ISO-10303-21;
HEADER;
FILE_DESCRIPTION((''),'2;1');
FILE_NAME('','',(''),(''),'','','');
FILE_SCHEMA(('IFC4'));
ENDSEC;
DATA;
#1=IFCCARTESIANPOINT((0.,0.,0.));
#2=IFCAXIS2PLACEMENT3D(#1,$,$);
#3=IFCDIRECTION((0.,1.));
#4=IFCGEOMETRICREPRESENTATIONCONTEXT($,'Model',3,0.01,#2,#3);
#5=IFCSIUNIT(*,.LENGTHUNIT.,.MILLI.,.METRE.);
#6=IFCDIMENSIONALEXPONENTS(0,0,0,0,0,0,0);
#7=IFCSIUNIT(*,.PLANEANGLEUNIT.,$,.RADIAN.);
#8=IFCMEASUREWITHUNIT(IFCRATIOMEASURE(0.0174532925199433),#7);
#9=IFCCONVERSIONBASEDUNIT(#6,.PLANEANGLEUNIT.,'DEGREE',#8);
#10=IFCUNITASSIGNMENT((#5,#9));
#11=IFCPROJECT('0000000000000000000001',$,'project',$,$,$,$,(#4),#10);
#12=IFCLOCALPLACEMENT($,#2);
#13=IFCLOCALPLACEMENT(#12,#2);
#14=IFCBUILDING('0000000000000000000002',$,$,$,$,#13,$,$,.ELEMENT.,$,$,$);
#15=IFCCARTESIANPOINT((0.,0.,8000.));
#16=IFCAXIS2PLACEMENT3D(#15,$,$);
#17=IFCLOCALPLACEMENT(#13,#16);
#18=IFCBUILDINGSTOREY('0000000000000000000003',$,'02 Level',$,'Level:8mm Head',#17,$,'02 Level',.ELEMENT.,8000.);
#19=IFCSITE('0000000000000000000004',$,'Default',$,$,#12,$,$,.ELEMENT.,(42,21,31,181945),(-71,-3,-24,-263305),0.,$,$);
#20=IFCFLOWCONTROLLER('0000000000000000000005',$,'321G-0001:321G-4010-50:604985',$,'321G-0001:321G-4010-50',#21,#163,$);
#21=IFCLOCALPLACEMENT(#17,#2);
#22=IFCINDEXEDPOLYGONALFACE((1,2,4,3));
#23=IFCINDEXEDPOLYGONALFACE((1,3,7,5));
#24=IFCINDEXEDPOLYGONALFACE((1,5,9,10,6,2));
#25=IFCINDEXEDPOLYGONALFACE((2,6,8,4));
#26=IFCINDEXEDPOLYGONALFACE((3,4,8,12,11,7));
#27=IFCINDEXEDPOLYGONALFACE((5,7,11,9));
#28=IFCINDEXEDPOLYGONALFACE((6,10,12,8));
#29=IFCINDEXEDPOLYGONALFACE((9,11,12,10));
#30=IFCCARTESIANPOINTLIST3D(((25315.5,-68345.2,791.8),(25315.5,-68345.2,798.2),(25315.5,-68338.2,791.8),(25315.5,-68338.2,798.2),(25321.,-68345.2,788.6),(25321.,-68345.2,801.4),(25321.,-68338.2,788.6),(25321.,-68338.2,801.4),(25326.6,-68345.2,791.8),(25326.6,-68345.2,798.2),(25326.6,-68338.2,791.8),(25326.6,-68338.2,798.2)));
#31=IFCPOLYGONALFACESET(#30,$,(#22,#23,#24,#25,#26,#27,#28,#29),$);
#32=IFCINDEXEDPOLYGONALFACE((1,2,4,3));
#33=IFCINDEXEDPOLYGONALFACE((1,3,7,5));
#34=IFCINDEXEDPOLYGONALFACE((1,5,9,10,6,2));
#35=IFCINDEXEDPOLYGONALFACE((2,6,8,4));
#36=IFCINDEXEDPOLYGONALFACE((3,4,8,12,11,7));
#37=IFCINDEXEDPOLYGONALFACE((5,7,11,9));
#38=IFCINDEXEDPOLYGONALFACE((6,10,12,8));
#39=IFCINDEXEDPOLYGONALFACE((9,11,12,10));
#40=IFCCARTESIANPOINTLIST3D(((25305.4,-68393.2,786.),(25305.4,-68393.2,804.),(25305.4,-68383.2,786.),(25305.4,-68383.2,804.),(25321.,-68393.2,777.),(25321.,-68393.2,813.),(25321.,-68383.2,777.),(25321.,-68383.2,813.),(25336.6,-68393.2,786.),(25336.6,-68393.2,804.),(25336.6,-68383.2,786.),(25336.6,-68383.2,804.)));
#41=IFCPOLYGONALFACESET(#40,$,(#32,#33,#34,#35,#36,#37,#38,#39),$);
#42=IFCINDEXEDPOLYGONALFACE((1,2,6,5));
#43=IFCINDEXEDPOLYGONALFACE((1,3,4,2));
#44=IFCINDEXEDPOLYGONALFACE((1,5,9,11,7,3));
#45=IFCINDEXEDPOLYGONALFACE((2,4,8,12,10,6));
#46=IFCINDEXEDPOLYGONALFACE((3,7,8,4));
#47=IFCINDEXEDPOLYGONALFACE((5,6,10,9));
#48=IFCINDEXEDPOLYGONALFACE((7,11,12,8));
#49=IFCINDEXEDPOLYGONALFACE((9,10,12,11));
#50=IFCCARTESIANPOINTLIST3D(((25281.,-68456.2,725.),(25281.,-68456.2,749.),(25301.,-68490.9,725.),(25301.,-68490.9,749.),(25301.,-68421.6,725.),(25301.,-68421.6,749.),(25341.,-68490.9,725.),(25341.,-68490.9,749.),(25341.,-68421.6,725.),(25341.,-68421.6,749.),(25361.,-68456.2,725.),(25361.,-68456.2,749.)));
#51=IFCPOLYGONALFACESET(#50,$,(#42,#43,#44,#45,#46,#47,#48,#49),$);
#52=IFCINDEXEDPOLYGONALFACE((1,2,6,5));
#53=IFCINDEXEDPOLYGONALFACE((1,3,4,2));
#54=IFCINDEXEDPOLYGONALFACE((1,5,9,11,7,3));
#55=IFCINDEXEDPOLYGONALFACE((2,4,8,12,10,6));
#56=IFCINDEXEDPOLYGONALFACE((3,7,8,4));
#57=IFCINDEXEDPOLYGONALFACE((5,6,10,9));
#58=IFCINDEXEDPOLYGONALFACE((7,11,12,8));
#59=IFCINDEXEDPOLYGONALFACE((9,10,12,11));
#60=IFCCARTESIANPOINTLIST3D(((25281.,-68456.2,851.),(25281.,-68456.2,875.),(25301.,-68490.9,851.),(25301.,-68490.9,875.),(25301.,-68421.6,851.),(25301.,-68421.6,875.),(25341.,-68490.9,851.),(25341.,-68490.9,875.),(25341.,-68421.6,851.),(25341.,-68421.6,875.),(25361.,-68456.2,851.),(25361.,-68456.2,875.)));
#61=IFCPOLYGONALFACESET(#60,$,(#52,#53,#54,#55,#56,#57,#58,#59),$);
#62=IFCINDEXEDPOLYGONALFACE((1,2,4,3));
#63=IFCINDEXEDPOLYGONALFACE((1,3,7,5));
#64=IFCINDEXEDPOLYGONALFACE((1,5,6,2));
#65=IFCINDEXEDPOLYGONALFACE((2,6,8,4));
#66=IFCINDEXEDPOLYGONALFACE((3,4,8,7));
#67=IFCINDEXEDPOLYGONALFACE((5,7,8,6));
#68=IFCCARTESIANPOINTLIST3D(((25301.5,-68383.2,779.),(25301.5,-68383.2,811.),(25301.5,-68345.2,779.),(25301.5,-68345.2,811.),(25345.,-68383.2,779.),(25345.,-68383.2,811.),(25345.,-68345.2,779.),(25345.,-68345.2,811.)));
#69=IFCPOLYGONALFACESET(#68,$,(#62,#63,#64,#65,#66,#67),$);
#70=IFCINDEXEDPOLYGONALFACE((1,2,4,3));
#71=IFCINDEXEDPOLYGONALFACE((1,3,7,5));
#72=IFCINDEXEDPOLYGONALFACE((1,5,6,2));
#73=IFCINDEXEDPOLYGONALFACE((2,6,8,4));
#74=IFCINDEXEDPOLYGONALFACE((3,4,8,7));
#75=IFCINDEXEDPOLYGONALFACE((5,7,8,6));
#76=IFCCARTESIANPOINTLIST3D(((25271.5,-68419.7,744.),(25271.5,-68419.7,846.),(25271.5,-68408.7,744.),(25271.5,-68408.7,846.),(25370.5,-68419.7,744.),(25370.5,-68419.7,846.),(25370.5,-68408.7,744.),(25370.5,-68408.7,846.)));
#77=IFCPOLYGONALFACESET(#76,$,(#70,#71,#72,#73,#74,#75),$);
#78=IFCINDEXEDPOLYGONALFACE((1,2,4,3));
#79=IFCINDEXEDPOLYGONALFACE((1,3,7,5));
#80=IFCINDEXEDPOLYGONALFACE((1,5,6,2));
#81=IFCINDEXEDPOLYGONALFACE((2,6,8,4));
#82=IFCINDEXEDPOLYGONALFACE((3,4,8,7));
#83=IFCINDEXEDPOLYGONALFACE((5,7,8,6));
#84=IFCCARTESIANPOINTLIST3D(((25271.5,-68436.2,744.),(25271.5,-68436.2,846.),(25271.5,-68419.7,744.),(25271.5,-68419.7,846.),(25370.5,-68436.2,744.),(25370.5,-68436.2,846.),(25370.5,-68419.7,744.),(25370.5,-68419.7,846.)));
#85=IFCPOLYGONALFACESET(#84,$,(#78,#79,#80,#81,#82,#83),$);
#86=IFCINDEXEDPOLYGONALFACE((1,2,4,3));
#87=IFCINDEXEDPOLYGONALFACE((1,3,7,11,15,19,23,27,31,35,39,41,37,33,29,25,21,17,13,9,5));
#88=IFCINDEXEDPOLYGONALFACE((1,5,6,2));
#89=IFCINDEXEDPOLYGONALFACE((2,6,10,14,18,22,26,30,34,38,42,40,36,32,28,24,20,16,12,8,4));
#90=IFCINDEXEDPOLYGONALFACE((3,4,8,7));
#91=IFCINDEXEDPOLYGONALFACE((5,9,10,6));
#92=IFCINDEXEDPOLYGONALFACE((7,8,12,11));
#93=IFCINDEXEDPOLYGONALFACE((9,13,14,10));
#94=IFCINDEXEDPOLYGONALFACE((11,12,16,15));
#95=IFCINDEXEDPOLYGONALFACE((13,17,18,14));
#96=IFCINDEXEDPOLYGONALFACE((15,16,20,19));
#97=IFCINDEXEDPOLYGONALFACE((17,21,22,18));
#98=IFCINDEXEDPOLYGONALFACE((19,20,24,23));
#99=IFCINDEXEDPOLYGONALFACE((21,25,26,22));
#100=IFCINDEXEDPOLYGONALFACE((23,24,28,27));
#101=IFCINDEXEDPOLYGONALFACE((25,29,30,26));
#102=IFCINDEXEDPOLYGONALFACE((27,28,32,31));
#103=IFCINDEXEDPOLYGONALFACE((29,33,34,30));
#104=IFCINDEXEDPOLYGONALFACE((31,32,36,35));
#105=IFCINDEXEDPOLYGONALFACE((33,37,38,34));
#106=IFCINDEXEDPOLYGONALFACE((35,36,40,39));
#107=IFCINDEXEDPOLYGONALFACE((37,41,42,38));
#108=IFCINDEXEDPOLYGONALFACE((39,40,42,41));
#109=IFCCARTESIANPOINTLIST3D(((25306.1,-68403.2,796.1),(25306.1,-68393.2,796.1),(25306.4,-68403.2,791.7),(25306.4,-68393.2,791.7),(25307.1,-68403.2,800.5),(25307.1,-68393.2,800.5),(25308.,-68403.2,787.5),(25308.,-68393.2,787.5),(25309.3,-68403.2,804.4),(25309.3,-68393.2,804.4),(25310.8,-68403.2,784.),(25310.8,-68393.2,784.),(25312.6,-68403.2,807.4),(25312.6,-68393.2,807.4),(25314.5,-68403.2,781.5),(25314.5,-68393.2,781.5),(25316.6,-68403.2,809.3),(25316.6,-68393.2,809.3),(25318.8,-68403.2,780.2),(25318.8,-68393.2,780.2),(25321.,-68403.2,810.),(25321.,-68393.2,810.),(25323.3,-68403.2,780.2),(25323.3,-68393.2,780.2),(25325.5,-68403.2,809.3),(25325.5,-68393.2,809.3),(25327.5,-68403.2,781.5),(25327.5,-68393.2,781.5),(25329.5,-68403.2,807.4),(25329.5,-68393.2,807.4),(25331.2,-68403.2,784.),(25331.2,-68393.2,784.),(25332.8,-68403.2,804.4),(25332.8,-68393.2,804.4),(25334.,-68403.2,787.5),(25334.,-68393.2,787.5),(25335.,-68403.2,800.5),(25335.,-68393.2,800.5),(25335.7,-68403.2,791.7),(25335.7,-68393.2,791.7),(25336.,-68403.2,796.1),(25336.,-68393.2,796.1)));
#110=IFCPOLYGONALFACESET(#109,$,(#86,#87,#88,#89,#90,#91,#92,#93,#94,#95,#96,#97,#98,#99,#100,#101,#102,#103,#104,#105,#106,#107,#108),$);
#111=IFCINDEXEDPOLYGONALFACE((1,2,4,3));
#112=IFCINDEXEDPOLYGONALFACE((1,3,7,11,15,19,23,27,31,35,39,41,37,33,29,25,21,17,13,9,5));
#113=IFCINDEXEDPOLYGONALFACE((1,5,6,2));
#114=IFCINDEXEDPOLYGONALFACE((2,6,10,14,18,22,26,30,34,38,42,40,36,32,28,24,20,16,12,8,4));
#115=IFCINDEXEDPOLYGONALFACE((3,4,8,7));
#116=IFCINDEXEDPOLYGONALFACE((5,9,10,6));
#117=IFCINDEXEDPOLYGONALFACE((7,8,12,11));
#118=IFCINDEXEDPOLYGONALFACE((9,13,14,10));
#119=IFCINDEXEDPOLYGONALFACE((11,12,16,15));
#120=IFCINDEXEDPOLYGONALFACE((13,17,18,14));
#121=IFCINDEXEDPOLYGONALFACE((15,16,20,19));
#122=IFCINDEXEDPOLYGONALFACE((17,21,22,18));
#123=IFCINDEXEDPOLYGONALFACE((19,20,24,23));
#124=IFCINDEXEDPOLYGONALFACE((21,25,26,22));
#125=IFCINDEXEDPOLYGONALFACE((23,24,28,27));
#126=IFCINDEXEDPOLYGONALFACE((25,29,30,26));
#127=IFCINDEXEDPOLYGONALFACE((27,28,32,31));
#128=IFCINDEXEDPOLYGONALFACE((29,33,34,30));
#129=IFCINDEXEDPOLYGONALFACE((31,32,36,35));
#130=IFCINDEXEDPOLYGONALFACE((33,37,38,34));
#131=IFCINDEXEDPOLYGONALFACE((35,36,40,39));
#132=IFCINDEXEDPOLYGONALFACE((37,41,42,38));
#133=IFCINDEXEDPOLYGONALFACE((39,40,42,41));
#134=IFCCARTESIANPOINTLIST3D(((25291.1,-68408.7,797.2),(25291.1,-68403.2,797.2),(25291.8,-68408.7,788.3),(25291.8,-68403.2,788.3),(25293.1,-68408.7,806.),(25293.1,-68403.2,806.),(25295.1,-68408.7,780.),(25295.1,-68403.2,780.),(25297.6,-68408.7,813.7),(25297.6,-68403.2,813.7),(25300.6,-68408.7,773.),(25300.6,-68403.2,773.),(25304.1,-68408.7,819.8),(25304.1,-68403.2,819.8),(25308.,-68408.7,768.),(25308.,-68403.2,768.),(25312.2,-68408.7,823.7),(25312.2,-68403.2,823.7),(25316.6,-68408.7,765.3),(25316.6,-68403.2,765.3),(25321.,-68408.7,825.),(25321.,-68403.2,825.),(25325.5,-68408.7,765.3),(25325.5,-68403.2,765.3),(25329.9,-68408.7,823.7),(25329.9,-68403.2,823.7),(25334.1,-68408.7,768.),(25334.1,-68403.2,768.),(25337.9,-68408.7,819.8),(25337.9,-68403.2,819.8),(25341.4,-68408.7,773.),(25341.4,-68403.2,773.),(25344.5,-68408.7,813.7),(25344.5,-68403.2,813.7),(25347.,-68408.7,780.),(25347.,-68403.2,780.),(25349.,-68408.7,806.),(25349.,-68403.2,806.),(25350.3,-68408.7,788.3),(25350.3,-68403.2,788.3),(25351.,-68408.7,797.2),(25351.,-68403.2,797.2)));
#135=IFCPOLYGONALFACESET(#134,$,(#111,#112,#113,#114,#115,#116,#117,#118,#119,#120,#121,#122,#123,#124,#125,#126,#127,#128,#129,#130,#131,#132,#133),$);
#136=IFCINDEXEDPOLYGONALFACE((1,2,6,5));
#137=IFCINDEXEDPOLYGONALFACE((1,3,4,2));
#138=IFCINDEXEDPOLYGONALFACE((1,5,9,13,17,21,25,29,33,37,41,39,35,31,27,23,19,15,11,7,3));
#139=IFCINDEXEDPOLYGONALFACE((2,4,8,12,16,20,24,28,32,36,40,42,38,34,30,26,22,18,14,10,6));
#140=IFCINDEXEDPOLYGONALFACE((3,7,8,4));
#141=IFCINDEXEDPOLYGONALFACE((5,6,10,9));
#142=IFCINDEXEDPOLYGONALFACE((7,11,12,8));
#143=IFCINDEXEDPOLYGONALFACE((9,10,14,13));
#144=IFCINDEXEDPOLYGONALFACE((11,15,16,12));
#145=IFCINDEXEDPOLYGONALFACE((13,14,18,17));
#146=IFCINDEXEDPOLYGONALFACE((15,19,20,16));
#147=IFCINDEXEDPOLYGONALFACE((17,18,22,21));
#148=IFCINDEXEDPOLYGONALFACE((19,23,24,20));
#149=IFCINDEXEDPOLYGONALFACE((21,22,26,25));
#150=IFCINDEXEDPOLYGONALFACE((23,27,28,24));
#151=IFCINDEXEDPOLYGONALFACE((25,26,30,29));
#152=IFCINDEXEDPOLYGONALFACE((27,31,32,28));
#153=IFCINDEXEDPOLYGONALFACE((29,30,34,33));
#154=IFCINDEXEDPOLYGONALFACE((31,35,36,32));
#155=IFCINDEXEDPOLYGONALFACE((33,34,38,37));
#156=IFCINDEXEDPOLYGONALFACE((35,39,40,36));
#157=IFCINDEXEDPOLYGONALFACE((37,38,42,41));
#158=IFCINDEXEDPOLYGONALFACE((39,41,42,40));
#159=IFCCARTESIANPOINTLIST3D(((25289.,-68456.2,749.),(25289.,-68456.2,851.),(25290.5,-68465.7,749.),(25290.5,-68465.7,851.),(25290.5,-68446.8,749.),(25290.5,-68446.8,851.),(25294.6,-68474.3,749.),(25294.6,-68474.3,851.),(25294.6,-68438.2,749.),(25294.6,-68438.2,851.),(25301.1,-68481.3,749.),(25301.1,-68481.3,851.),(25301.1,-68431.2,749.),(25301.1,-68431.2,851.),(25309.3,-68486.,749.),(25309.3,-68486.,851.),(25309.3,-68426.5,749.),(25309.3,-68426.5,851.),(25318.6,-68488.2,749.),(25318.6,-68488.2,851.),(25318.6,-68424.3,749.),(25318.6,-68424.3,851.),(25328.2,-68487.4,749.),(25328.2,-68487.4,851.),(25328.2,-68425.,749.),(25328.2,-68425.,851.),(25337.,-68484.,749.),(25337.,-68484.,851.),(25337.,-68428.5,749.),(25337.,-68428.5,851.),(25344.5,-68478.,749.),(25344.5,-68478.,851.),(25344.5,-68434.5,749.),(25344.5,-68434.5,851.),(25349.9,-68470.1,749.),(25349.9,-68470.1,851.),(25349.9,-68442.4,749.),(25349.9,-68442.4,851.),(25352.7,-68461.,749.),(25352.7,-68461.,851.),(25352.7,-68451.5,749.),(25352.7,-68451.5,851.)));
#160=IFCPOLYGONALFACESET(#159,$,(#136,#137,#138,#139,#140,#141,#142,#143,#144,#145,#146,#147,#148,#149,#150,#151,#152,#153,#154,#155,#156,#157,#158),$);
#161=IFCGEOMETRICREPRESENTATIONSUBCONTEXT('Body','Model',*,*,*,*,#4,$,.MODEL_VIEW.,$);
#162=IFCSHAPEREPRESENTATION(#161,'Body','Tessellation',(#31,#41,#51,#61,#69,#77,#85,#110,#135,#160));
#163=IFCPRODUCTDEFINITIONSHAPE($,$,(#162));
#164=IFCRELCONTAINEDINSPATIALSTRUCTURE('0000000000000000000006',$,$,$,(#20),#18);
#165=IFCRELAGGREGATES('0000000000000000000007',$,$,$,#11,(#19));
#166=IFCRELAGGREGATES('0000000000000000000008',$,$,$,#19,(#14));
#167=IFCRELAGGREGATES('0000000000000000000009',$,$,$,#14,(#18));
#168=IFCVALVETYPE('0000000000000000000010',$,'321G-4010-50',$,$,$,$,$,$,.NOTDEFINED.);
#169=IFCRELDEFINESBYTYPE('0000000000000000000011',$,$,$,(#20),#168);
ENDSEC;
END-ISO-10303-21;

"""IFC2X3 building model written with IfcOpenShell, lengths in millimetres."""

from ifc_helpers import new_model, entity, si_unit, converted_unit, direction, frame, frame_2d, origin, origin_2d_with_axis, place, context, subcontext, project, spatial, polyline, rectangle, circle, outline, extrude, source, transform, mapped, type_object, type_shapes, element, save


model = new_model("IFC2X3")

# Units and contexts
model_context = context("Model", 3, precision=0.01, world=origin(), true_north=direction((0.0, 1.0)))
body_context = subcontext(model_context, "Body", "Model", "MODEL_VIEW")
ifc_project = project(units=[si_unit("LENGTHUNIT", "METRE", prefix="MILLI"), converted_unit("PLANEANGLEUNIT", "DEGREE", entity("IfcRatioMeasure", 0.0174532925199433), si_unit("PLANEANGLEUNIT", "RADIAN"), dimensions=[0, 0, 0, 0, 0, 0, 0])], contexts=[model_context])

# Site, building, storey
site_placement = place(None, origin())
site = spatial("IfcSite", under=ifc_project, at=site_placement, Name="Default", CompositionType="ELEMENT", RefLatitude=(42, 21, 31, 181945), RefLongitude=(-71, -3, -24, -263305), RefElevation=0.0)
building_placement = place(site_placement, origin())
building = spatial("IfcBuilding", under=site, at=building_placement, CompositionType="ELEMENT")
storey_placement = place(building_placement, frame((0.0, 0.0, 8000.0)))
storey = spatial("IfcBuildingStorey", under=building, at=storey_placement, Name="02 Level", ObjectType="Level:8mm Head", LongName="02 Level", CompositionType="ELEMENT", Elevation=8000.0)

# Flow controller
valve_type_1 = type_object("IfcValveType", Name="321G-4010-50", PredefinedType="NOTDEFINED")
shared_shape_1 = source(origin(), body_context, "Body", "SweptSolid", [
    extrude(outline(polyline([(-3.2, -5.5), (3.2, -5.5), (6.4, 0.0), (3.2, 5.5), (-3.2, 5.5), (-6.4, 0.0), (-3.2, -5.5)])), frame((-5.0, 0.0, 111.0), z_axis=(0.0, 0.0, 1.0), x_axis=(0.5, 0.866025, 0.0)), (0.0, 0.0, 1.0), 7.0),
    extrude(outline(polyline([(-9.0, -15.6), (9.0, -15.6), (18.0, 0.0), (9.0, 15.6), (-9.0, 15.6), (-18.0, 0.0), (-9.0, -15.6)])), frame((-5.0, 0.0, 63.0), z_axis=(0.0, 0.0, 1.0), x_axis=(0.5, 0.866025, 0.0)), (0.0, 0.0, 1.0), 10.0),
    extrude(outline(polyline([(-20.0, -34.6), (20.0, -34.6), (40.0, 0.0), (20.0, 34.6), (-20.0, 34.6), (-40.0, 0.0), (-20.0, -34.6)])), frame((-75.0, 0.0, 0.0), z_axis=(1.0, 0.0, 0.0), x_axis=(0.0, -0.5, -0.866025)), (0.0, 0.0, 1.0), 24.0),
    extrude(outline(polyline([(-20.0, -34.6), (20.0, -34.6), (40.0, 0.0), (20.0, 34.6), (-20.0, 34.6), (-40.0, 0.0), (-20.0, -34.6)])), frame((51.0, 0.0, 0.0), z_axis=(1.0, 0.0, 0.0), x_axis=(0.0, -0.5, -0.866025)), (0.0, 0.0, 1.0), 24.0),
    extrude(rectangle(XDim=43.5, YDim=32.0, at=frame_2d((0.0, 0.0), x_axis=(1.0, 0.0))), frame((-5.0, 2.2, 73.0), z_axis=(0.0, 0.0, 1.0), x_axis=(0.0, -1.0, 0.0)), (0.0, 0.0, 1.0), 38.0),
    extrude(rectangle(XDim=99.0, YDim=102.0, at=origin_2d_with_axis()), frame((-5.0, 0.0, 36.5), z_axis=(0.0, 0.0, 1.0), x_axis=(0.0, -1.0, 0.0)), (0.0, 0.0, 1.0), 11.0),
    extrude(rectangle(XDim=99.0, YDim=102.0, at=origin_2d_with_axis()), frame((-5.0, 0.0, 20.0), z_axis=(0.0, 0.0, 1.0), x_axis=(0.0, -1.0, 0.0)), (0.0, 0.0, 1.0), 16.5),
    extrude(circle(Radius=15.0, at=frame_2d((0.0, 0.0), x_axis=(1.0, 0.0))), frame((-5.0, 0.0, 53.0)), (0.0, 0.0, 1.0), 10.0),
    extrude(circle(Radius=30.0, at=frame_2d((0.0, 0.0), x_axis=(1.0, 0.0))), frame((-5.0, 0.0, 47.5)), (0.0, 0.0, 1.0), 5.5),
    extrude(circle(Radius=32.0, at=frame_2d((0.0, 0.0), x_axis=(1.0, 0.0))), frame((-51.0, 0.0, 0.0), z_axis=(1.0, 0.0, 0.0), x_axis=(0.0, -1.0, 0.0)), (0.0, 0.0, 1.0), 102.0),
])
type_shapes(valve_type_1, [shared_shape_1])
flow_controller_1_placement = place(storey_placement, frame((25321.0, -68456.2, 800.0), z_axis=(0.0, 1.0, 0.0), x_axis=(0.0, 0.0, 1.0)))
element("IfcFlowController", 1, at=flow_controller_1_placement, inside=storey, type_object=valve_type_1, Name="321G-0001:321G-4010-50:604985", ObjectType="321G-0001:321G-4010-50", context=body_context, shape_type="MappedRepresentation", body=[
    mapped(shared_shape_1, transform((0.0, 0.0, 0.0), scale=1.0)),
])

save(model, "model.ifc")
